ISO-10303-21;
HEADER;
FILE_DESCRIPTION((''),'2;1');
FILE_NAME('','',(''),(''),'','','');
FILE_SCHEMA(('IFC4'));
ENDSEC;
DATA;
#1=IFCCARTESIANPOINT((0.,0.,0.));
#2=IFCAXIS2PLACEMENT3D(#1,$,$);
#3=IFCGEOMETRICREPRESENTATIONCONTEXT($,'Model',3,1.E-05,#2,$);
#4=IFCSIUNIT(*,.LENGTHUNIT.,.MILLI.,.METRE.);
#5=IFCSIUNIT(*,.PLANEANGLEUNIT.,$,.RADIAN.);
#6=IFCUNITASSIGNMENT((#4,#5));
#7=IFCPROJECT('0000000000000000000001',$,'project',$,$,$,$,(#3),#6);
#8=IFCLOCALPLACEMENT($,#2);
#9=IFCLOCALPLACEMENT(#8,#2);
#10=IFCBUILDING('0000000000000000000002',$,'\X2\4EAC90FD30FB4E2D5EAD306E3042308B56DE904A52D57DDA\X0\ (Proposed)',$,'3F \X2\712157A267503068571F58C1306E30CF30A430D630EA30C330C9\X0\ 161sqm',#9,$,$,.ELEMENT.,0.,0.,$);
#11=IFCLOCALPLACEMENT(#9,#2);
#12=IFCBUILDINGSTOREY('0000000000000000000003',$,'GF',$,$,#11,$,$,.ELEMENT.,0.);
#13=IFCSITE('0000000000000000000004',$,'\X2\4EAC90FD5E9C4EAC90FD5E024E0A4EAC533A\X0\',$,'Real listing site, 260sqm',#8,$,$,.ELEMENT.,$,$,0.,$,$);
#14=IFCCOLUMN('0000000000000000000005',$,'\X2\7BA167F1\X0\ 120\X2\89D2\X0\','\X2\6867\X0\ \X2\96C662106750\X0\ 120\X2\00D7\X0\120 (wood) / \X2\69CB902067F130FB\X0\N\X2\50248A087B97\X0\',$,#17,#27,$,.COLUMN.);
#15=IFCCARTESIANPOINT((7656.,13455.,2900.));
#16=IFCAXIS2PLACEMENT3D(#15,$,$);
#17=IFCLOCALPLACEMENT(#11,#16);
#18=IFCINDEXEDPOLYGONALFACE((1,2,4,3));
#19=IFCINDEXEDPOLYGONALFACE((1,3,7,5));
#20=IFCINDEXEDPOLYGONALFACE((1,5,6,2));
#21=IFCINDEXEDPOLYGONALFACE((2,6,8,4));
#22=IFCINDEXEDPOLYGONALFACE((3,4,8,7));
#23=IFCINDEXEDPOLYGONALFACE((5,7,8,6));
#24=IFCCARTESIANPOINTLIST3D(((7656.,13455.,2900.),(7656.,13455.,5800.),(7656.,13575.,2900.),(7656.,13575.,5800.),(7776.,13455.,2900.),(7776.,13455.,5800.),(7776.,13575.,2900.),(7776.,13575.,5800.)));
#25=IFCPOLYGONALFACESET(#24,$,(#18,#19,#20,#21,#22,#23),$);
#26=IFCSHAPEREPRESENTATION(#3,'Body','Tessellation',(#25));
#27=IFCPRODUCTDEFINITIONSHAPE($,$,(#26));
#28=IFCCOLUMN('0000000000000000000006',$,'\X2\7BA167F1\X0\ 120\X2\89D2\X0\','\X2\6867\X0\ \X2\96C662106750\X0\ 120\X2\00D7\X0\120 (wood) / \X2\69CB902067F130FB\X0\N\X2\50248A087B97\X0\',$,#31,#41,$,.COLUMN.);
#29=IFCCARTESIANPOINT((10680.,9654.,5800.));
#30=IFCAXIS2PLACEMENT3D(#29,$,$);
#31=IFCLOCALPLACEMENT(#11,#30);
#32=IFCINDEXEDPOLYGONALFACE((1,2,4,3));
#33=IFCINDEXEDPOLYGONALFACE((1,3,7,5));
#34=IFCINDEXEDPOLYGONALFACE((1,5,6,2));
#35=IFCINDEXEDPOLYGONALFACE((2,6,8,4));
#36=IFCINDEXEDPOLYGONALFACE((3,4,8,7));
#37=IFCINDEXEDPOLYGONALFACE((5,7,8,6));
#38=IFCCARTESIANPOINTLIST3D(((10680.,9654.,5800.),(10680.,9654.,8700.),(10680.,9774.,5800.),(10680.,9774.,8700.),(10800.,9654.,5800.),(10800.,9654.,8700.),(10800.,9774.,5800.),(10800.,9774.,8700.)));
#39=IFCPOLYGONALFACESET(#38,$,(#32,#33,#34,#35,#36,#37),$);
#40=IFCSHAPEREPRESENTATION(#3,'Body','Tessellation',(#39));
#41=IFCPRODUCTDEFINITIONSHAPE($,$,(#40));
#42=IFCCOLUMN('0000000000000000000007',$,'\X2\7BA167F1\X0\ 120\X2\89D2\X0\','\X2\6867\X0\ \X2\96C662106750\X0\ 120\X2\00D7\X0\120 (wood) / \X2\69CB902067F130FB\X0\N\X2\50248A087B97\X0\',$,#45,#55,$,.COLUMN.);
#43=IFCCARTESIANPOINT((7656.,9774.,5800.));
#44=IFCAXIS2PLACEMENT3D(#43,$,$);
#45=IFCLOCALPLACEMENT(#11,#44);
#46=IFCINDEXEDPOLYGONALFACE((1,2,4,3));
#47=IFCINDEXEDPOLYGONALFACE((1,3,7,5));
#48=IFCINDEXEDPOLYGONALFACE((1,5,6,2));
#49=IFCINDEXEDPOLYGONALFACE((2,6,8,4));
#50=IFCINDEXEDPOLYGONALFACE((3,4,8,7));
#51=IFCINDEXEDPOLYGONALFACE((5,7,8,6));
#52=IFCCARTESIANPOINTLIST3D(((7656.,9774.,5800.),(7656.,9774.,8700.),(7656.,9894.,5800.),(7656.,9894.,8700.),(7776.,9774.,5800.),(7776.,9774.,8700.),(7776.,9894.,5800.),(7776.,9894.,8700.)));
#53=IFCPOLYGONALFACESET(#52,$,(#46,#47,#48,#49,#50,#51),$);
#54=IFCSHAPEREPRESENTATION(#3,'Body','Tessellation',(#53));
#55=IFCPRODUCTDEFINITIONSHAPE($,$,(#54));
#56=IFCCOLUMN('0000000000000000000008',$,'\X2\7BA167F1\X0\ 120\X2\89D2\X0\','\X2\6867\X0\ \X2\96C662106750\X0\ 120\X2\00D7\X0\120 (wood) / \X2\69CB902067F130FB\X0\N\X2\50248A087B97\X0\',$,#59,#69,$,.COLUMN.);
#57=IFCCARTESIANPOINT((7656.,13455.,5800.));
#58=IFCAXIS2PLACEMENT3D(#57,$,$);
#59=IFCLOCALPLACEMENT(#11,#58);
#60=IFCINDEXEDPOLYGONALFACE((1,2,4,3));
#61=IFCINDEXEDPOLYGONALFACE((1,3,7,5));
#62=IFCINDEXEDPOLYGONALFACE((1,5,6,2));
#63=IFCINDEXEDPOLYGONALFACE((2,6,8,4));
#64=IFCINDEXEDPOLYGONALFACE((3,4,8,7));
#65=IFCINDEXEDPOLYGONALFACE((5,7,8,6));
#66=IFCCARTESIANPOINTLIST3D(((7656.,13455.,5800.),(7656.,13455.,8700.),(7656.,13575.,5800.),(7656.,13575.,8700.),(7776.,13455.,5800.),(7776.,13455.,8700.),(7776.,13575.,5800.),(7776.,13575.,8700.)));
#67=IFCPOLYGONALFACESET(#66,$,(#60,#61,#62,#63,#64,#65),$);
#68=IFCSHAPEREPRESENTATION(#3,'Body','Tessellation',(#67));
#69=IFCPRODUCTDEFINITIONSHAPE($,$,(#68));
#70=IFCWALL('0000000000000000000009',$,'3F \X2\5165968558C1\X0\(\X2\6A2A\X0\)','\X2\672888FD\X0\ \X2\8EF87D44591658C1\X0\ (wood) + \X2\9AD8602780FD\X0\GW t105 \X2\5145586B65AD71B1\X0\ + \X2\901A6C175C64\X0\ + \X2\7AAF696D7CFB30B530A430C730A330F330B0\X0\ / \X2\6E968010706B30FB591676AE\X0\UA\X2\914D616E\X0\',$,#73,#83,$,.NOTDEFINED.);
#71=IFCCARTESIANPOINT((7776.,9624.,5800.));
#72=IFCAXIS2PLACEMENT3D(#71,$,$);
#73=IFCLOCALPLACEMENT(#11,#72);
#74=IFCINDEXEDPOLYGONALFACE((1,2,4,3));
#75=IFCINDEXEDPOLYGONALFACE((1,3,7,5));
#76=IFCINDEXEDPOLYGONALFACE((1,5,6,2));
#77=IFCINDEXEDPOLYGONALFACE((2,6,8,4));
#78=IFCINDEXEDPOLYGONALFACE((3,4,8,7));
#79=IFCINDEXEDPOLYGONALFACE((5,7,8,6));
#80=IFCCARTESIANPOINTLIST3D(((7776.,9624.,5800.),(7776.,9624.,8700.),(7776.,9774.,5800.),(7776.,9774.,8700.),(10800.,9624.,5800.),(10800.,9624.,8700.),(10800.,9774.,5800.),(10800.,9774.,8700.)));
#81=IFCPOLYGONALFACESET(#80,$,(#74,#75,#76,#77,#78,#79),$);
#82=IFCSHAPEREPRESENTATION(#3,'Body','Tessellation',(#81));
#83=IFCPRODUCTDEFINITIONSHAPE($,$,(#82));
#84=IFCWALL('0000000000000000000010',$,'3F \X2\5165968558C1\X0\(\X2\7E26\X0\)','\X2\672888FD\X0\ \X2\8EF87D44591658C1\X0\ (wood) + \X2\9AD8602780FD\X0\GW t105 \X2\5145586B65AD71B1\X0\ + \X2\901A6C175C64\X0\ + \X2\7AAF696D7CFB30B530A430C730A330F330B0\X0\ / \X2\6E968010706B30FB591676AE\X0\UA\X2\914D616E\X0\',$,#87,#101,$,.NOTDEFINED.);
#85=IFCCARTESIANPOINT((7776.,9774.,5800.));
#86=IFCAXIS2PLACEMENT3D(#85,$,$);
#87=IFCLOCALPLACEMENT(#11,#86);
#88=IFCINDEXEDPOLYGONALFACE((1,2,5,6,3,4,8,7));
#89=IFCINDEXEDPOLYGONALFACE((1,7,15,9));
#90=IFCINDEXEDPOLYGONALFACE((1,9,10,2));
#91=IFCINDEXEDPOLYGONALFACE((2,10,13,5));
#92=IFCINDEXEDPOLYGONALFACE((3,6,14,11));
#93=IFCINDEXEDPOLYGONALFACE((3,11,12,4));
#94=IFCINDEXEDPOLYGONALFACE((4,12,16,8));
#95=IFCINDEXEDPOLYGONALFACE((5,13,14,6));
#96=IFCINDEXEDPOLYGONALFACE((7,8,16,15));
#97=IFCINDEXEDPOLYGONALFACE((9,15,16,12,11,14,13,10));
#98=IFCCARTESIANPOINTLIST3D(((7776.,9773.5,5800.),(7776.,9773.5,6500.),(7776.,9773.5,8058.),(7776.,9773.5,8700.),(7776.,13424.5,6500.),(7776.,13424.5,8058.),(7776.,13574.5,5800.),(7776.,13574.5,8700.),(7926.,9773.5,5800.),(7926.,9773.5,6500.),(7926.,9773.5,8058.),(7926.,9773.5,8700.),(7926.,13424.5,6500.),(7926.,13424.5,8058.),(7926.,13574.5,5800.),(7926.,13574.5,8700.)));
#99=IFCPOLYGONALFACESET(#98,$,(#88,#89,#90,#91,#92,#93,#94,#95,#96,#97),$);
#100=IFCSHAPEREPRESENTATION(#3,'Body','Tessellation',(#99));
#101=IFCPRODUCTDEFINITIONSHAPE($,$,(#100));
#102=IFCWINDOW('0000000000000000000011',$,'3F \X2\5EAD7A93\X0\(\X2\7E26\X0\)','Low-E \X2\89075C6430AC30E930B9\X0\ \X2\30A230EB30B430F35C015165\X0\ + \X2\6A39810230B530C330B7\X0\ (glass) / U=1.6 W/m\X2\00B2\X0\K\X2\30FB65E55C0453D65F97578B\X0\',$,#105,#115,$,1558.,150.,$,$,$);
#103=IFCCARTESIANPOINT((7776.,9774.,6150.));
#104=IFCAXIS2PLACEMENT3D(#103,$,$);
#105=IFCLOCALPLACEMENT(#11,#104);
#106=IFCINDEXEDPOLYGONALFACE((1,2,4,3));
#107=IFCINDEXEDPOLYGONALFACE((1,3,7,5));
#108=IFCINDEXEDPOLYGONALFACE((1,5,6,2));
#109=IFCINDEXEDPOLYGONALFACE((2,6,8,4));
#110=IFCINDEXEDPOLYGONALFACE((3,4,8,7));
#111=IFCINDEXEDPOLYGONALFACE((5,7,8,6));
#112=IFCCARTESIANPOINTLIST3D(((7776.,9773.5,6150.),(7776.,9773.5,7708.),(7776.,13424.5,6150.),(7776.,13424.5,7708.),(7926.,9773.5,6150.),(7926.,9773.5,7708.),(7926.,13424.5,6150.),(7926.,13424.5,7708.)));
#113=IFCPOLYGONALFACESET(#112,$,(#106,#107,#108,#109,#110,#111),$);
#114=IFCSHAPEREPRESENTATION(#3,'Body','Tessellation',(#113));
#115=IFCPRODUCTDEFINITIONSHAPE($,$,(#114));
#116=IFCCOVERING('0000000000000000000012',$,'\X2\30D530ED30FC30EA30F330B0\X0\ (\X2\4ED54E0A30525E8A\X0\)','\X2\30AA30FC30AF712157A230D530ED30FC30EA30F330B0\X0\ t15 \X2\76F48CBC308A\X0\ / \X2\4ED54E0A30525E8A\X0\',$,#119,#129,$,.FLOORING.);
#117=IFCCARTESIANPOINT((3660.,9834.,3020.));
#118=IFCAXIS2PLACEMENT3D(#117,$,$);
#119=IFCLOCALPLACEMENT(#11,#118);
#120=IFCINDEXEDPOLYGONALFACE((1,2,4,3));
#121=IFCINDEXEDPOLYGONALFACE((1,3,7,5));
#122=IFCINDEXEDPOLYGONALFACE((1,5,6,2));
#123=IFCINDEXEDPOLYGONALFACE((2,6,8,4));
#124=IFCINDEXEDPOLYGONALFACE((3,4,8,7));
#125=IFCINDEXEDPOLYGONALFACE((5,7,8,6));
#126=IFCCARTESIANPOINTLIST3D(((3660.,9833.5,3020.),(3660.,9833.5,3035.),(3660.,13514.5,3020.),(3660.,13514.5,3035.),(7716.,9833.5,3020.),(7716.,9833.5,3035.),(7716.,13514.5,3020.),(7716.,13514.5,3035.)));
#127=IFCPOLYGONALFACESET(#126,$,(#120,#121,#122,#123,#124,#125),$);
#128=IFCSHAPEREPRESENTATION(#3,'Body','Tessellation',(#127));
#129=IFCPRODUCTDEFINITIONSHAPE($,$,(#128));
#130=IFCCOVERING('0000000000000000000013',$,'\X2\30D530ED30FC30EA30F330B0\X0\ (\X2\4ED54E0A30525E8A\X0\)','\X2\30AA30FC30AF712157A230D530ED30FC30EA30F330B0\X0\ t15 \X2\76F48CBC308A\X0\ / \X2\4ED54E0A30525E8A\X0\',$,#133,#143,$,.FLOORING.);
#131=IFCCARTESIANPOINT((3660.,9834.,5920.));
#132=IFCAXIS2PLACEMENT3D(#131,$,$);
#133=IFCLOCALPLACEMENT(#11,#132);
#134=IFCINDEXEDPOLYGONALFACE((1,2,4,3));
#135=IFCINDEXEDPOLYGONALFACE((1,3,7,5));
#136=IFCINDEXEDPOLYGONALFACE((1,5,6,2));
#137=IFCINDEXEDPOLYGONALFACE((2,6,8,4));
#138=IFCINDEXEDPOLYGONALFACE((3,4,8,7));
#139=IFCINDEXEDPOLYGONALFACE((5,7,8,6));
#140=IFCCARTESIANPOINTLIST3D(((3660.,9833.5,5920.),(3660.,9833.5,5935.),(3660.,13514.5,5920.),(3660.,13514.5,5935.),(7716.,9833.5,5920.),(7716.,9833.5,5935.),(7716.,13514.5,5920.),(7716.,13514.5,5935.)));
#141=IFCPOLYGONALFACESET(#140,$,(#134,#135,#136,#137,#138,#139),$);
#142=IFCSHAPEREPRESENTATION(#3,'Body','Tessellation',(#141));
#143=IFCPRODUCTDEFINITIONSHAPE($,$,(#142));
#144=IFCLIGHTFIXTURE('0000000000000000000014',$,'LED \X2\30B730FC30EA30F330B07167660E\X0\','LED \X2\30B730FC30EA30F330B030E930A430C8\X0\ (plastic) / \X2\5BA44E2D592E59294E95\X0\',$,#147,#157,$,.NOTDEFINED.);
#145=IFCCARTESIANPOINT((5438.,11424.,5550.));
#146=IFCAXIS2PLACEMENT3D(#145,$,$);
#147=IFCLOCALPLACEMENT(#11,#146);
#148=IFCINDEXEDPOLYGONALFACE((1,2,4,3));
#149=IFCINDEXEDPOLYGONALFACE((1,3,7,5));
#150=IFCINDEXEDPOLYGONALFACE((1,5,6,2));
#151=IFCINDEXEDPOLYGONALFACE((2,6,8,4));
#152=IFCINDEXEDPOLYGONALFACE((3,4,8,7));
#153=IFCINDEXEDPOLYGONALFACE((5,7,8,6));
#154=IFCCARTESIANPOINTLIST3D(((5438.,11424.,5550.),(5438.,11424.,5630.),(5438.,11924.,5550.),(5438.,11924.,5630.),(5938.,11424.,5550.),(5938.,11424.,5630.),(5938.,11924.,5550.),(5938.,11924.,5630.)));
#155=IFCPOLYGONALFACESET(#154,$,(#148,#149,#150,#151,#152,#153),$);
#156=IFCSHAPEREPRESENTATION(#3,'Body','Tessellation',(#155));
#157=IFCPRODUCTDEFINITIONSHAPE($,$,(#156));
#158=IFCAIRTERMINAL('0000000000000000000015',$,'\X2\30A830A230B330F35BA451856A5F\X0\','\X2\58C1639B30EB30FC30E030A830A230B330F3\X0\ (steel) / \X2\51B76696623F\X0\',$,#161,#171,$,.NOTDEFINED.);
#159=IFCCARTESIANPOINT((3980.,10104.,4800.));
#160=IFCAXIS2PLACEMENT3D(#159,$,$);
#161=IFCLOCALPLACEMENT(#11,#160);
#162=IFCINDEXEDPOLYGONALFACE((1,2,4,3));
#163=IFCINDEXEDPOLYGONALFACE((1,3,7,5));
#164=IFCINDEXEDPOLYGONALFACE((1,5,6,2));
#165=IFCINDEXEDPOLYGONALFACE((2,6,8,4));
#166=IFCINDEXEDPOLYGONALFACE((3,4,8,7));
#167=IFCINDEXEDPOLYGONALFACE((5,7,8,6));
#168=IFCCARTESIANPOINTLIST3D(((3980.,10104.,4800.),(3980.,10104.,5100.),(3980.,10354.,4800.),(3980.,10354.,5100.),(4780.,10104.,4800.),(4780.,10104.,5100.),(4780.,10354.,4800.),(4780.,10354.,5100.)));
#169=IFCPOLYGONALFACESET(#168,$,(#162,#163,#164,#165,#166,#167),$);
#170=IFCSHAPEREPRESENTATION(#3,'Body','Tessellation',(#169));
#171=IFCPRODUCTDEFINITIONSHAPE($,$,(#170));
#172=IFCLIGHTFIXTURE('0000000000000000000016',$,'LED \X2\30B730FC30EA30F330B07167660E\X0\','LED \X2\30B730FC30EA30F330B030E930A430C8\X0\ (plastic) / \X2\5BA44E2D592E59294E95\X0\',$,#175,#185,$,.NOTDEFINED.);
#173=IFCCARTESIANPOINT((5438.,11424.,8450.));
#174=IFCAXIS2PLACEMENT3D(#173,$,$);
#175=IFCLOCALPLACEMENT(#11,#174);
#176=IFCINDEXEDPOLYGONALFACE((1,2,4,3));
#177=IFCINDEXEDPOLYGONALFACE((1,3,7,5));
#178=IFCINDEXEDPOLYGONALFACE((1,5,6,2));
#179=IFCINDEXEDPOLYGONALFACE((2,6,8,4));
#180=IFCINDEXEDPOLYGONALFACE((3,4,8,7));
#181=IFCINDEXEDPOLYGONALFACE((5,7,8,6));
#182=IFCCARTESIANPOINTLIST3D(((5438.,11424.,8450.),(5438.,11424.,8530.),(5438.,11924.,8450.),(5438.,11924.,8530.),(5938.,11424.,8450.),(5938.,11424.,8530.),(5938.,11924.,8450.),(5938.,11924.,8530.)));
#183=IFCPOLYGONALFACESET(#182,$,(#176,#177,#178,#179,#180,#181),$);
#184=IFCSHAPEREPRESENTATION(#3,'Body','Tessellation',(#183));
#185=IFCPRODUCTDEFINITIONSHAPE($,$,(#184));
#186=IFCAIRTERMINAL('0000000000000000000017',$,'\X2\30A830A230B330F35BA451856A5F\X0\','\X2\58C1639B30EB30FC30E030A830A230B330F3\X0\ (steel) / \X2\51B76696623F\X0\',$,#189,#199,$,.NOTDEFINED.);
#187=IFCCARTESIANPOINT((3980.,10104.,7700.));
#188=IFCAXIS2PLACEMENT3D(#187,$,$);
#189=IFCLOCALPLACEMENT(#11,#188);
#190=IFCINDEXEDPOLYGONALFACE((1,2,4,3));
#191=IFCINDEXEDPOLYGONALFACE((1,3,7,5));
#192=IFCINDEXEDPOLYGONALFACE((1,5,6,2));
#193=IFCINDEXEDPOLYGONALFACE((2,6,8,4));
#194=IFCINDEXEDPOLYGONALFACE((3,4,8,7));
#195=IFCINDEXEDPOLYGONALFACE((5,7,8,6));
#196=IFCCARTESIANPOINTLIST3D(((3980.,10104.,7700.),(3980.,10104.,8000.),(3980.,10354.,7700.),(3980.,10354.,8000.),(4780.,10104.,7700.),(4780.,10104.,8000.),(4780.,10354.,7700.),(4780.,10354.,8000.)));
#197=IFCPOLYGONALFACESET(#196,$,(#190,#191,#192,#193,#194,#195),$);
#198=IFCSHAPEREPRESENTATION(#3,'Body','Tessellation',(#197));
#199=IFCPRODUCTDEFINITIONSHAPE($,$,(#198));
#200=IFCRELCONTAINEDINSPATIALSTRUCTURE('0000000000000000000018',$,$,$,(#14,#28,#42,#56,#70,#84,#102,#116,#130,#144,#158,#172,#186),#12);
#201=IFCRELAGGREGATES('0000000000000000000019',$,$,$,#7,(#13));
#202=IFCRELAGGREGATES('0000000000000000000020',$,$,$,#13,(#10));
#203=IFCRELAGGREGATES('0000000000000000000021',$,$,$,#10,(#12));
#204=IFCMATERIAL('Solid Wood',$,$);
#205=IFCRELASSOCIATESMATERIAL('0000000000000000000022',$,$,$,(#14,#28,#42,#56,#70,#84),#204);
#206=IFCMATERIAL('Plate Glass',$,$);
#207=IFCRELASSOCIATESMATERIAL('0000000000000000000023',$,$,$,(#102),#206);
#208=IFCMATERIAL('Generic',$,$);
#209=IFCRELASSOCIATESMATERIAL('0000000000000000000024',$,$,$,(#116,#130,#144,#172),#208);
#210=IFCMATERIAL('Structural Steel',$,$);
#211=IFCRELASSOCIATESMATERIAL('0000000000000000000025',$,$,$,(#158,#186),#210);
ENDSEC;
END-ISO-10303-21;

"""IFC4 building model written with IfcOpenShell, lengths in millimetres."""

from ifc_helpers import new_model, si_unit, frame, frame_2d, origin, place, context, project, spatial, rectangle, extrude, material, element, fill, save


model = new_model("IFC4")

# Units and contexts
model_context = context("Model", 3, precision=1e-05, world=origin())
ifc_project = project(units=[si_unit("LENGTHUNIT", "METRE", prefix="MILLI"), si_unit("PLANEANGLEUNIT", "RADIAN")], contexts=[model_context])

# Site, building, storey
site_placement = place(None, origin())
site = spatial("IfcSite", under=ifc_project, at=site_placement, Name="京都府京都市上京区", ObjectType="Real listing site, 260sqm", CompositionType="ELEMENT", RefElevation=0.0)
building_placement = place(site_placement, origin())
building = spatial("IfcBuilding", under=site, at=building_placement, Name="京都・中庭のある回遊動線 (Proposed)", ObjectType="3F 無垢材と土壁のハイブリッド 161sqm", CompositionType="ELEMENT", ElevationOfRefHeight=0.0, ElevationOfTerrain=0.0)
storey_placement = place(building_placement, origin())
storey = spatial("IfcBuildingStorey", under=building, at=storey_placement, Name="GF", CompositionType="ELEMENT", Elevation=0.0)

# Columns
ifc_material_1 = material(Name="Solid Wood")
column_1_placement = place(storey_placement, frame((7656.0, 13455.0, 2900.0)))
element("IfcColumn", 1, at=column_1_placement, inside=storey, material=ifc_material_1, Name="管柱 120角", Description="桧 集成材 120×120 (wood) / 構造柱・N値計算", PredefinedType="COLUMN", context=model_context, shape_type="SweptSolid", body=[
    extrude(rectangle(XDim=120.0, YDim=120.0, at=frame_2d((60.0, 60.0))), frame((7656.0, 13455.0, 2900.0)), (0.0, 0.0, 1.0), 2900.0),
])
column_2_placement = place(storey_placement, frame((10680.0, 9654.0, 5800.0)))
element("IfcColumn", 2, at=column_2_placement, inside=storey, material=ifc_material_1, Name="管柱 120角", Description="桧 集成材 120×120 (wood) / 構造柱・N値計算", PredefinedType="COLUMN", context=model_context, shape_type="SweptSolid", body=[
    extrude(rectangle(XDim=120.0, YDim=120.0, at=frame_2d((60.0, 60.0))), frame((10680.0, 9654.0, 5800.0)), (0.0, 0.0, 1.0), 2900.0),
])
column_3_placement = place(storey_placement, frame((7656.0, 9774.0, 5800.0)))
element("IfcColumn", 3, at=column_3_placement, inside=storey, material=ifc_material_1, Name="管柱 120角", Description="桧 集成材 120×120 (wood) / 構造柱・N値計算", PredefinedType="COLUMN", context=model_context, shape_type="SweptSolid", body=[
    extrude(rectangle(XDim=120.0, YDim=120.0, at=frame_2d((60.0, 60.0))), frame((7656.0, 9774.0, 5800.0)), (0.0, 0.0, 1.0), 2900.0),
])
column_4_placement = place(storey_placement, frame((7656.0, 13455.0, 5800.0)))
element("IfcColumn", 4, at=column_4_placement, inside=storey, material=ifc_material_1, Name="管柱 120角", Description="桧 集成材 120×120 (wood) / 構造柱・N値計算", PredefinedType="COLUMN", context=model_context, shape_type="SweptSolid", body=[
    extrude(rectangle(XDim=120.0, YDim=120.0, at=frame_2d((60.0, 60.0))), frame((7656.0, 13455.0, 5800.0)), (0.0, 0.0, 1.0), 2900.0),
])

# Wall
wall_1_placement = place(storey_placement, frame((7776.0, 9624.0, 5800.0)))
element("IfcWall", 5, at=wall_1_placement, inside=storey, material=ifc_material_1, Name="3F 入隅壁(横)", Description="木製 軸組外壁 (wood) + 高性能GW t105 充填断熱 + 通気層 + 窯業系サイディング / 準耐火・外皮UA配慮", PredefinedType="NOTDEFINED", context=model_context, shape_type="SweptSolid", body=[
    extrude(rectangle(XDim=3024.0, YDim=150.0, at=frame_2d((1512.0, 75.0))), frame((7776.0, 9624.0, 5800.0)), (0.0, 0.0, 1.0), 2900.0),
])

# Wall, opening, window
wall_2_placement = place(storey_placement, frame((7776.0, 9774.0, 5800.0)))
wall_2 = element("IfcWall", 6, at=wall_2_placement, inside=storey, material=ifc_material_1, Name="3F 入隅壁(縦)", Description="木製 軸組外壁 (wood) + 高性能GW t105 充填断熱 + 通気層 + 窯業系サイディング / 準耐火・外皮UA配慮", PredefinedType="NOTDEFINED", context=model_context, shape_type="SweptSolid", body=[
    extrude(rectangle(XDim=150.0, YDim=3801.0, at=frame_2d((75.0, 1900.0))), frame((7776.0, 9774.0, 5800.0)), (0.0, 0.0, 1.0), 2900.0),
])
opening_placement = place(storey_placement, frame((7776.0, 9774.0, 6150.0)))
opening = element("IfcOpeningElement", 7, at=opening_placement, cuts=wall_2, PredefinedType="NOTDEFINED", context=model_context, shape_type="SweptSolid", body=[
    extrude(rectangle(XDim=150.0, YDim=3651.0, at=frame_2d((75.0, 1825.0))), frame((7776.0, 9774.0, 6150.0)), (0.0, 0.0, 1.0), 1558.0),
])
ifc_material_2 = material(Name="Plate Glass")
window_placement = place(storey_placement, frame((7776.0, 9774.0, 6150.0)))
window = element("IfcWindow", 8, at=window_placement, inside=storey, material=ifc_material_2, Name="3F 庭窓(縦)", Description="Low-E 複層ガラス アルゴン封入 + 樹脂サッシ (glass) / U=1.6 W/m²K・日射取得型", OverallHeight=1558.0, OverallWidth=150.0, context=model_context, shape_type="SweptSolid", body=[
    extrude(rectangle(XDim=150.0, YDim=3651.0, at=frame_2d((75.0, 1825.0))), frame((7776.0, 9774.0, 6150.0)), (0.0, 0.0, 1.0), 1558.0),
])
fill(opening, window)

# Coverings
ifc_material_3 = material(Name="Generic")
covering_1_placement = place(storey_placement, frame((3660.0, 9834.0, 3020.0)))
element("IfcCovering", 9, at=covering_1_placement, inside=storey, material=ifc_material_3, Name="フローリング (仕上げ床)", Description="オーク無垢フローリング t15 直貼り / 仕上げ床", PredefinedType="FLOORING", context=model_context, shape_type="SweptSolid", body=[
    extrude(rectangle(XDim=4056.0, YDim=3681.0, at=frame_2d((2028.0, 1840.0))), frame((3660.0, 9834.0, 3020.0)), (0.0, 0.0, 1.0), 15.0),
])
covering_2_placement = place(storey_placement, frame((3660.0, 9834.0, 5920.0)))
element("IfcCovering", 10, at=covering_2_placement, inside=storey, material=ifc_material_3, Name="フローリング (仕上げ床)", Description="オーク無垢フローリング t15 直貼り / 仕上げ床", PredefinedType="FLOORING", context=model_context, shape_type="SweptSolid", body=[
    extrude(rectangle(XDim=4056.0, YDim=3681.0, at=frame_2d((2028.0, 1840.0))), frame((3660.0, 9834.0, 5920.0)), (0.0, 0.0, 1.0), 15.0),
])

# Light fixture
light_fixture_1_placement = place(storey_placement, frame((5438.0, 11424.0, 5550.0)))
element("IfcLightFixture", 11, at=light_fixture_1_placement, inside=storey, material=ifc_material_3, Name="LED シーリング照明", Description="LED シーリングライト (plastic) / 室中央天井", PredefinedType="NOTDEFINED", context=model_context, shape_type="SweptSolid", body=[
    extrude(rectangle(XDim=500.0, YDim=500.0, at=frame_2d((250.0, 250.0))), frame((5438.0, 11424.0, 5550.0)), (0.0, 0.0, 1.0), 80.0),
])

# Air terminal
ifc_material_4 = material(Name="Structural Steel")
air_terminal_1_placement = place(storey_placement, frame((3980.0, 10104.0, 4800.0)))
element("IfcAirTerminal", 12, at=air_terminal_1_placement, inside=storey, material=ifc_material_4, Name="エアコン室内機", Description="壁掛ルームエアコン (steel) / 冷暖房", PredefinedType="NOTDEFINED", context=model_context, shape_type="SweptSolid", body=[
    extrude(rectangle(XDim=800.0, YDim=250.0, at=frame_2d((400.0, 125.0))), frame((3980.0, 10104.0, 4800.0)), (0.0, 0.0, 1.0), 300.0),
])

# Light fixture
light_fixture_2_placement = place(storey_placement, frame((5438.0, 11424.0, 8450.0)))
element("IfcLightFixture", 13, at=light_fixture_2_placement, inside=storey, material=ifc_material_3, Name="LED シーリング照明", Description="LED シーリングライト (plastic) / 室中央天井", PredefinedType="NOTDEFINED", context=model_context, shape_type="SweptSolid", body=[
    extrude(rectangle(XDim=500.0, YDim=500.0, at=frame_2d((250.0, 250.0))), frame((5438.0, 11424.0, 8450.0)), (0.0, 0.0, 1.0), 80.0),
])

# Air terminal
air_terminal_2_placement = place(storey_placement, frame((3980.0, 10104.0, 7700.0)))
element("IfcAirTerminal", 14, at=air_terminal_2_placement, inside=storey, material=ifc_material_4, Name="エアコン室内機", Description="壁掛ルームエアコン (steel) / 冷暖房", PredefinedType="NOTDEFINED", context=model_context, shape_type="SweptSolid", body=[
    extrude(rectangle(XDim=800.0, YDim=250.0, at=frame_2d((400.0, 125.0))), frame((3980.0, 10104.0, 7700.0)), (0.0, 0.0, 1.0), 300.0),
])

save(model, "model.ifc")
